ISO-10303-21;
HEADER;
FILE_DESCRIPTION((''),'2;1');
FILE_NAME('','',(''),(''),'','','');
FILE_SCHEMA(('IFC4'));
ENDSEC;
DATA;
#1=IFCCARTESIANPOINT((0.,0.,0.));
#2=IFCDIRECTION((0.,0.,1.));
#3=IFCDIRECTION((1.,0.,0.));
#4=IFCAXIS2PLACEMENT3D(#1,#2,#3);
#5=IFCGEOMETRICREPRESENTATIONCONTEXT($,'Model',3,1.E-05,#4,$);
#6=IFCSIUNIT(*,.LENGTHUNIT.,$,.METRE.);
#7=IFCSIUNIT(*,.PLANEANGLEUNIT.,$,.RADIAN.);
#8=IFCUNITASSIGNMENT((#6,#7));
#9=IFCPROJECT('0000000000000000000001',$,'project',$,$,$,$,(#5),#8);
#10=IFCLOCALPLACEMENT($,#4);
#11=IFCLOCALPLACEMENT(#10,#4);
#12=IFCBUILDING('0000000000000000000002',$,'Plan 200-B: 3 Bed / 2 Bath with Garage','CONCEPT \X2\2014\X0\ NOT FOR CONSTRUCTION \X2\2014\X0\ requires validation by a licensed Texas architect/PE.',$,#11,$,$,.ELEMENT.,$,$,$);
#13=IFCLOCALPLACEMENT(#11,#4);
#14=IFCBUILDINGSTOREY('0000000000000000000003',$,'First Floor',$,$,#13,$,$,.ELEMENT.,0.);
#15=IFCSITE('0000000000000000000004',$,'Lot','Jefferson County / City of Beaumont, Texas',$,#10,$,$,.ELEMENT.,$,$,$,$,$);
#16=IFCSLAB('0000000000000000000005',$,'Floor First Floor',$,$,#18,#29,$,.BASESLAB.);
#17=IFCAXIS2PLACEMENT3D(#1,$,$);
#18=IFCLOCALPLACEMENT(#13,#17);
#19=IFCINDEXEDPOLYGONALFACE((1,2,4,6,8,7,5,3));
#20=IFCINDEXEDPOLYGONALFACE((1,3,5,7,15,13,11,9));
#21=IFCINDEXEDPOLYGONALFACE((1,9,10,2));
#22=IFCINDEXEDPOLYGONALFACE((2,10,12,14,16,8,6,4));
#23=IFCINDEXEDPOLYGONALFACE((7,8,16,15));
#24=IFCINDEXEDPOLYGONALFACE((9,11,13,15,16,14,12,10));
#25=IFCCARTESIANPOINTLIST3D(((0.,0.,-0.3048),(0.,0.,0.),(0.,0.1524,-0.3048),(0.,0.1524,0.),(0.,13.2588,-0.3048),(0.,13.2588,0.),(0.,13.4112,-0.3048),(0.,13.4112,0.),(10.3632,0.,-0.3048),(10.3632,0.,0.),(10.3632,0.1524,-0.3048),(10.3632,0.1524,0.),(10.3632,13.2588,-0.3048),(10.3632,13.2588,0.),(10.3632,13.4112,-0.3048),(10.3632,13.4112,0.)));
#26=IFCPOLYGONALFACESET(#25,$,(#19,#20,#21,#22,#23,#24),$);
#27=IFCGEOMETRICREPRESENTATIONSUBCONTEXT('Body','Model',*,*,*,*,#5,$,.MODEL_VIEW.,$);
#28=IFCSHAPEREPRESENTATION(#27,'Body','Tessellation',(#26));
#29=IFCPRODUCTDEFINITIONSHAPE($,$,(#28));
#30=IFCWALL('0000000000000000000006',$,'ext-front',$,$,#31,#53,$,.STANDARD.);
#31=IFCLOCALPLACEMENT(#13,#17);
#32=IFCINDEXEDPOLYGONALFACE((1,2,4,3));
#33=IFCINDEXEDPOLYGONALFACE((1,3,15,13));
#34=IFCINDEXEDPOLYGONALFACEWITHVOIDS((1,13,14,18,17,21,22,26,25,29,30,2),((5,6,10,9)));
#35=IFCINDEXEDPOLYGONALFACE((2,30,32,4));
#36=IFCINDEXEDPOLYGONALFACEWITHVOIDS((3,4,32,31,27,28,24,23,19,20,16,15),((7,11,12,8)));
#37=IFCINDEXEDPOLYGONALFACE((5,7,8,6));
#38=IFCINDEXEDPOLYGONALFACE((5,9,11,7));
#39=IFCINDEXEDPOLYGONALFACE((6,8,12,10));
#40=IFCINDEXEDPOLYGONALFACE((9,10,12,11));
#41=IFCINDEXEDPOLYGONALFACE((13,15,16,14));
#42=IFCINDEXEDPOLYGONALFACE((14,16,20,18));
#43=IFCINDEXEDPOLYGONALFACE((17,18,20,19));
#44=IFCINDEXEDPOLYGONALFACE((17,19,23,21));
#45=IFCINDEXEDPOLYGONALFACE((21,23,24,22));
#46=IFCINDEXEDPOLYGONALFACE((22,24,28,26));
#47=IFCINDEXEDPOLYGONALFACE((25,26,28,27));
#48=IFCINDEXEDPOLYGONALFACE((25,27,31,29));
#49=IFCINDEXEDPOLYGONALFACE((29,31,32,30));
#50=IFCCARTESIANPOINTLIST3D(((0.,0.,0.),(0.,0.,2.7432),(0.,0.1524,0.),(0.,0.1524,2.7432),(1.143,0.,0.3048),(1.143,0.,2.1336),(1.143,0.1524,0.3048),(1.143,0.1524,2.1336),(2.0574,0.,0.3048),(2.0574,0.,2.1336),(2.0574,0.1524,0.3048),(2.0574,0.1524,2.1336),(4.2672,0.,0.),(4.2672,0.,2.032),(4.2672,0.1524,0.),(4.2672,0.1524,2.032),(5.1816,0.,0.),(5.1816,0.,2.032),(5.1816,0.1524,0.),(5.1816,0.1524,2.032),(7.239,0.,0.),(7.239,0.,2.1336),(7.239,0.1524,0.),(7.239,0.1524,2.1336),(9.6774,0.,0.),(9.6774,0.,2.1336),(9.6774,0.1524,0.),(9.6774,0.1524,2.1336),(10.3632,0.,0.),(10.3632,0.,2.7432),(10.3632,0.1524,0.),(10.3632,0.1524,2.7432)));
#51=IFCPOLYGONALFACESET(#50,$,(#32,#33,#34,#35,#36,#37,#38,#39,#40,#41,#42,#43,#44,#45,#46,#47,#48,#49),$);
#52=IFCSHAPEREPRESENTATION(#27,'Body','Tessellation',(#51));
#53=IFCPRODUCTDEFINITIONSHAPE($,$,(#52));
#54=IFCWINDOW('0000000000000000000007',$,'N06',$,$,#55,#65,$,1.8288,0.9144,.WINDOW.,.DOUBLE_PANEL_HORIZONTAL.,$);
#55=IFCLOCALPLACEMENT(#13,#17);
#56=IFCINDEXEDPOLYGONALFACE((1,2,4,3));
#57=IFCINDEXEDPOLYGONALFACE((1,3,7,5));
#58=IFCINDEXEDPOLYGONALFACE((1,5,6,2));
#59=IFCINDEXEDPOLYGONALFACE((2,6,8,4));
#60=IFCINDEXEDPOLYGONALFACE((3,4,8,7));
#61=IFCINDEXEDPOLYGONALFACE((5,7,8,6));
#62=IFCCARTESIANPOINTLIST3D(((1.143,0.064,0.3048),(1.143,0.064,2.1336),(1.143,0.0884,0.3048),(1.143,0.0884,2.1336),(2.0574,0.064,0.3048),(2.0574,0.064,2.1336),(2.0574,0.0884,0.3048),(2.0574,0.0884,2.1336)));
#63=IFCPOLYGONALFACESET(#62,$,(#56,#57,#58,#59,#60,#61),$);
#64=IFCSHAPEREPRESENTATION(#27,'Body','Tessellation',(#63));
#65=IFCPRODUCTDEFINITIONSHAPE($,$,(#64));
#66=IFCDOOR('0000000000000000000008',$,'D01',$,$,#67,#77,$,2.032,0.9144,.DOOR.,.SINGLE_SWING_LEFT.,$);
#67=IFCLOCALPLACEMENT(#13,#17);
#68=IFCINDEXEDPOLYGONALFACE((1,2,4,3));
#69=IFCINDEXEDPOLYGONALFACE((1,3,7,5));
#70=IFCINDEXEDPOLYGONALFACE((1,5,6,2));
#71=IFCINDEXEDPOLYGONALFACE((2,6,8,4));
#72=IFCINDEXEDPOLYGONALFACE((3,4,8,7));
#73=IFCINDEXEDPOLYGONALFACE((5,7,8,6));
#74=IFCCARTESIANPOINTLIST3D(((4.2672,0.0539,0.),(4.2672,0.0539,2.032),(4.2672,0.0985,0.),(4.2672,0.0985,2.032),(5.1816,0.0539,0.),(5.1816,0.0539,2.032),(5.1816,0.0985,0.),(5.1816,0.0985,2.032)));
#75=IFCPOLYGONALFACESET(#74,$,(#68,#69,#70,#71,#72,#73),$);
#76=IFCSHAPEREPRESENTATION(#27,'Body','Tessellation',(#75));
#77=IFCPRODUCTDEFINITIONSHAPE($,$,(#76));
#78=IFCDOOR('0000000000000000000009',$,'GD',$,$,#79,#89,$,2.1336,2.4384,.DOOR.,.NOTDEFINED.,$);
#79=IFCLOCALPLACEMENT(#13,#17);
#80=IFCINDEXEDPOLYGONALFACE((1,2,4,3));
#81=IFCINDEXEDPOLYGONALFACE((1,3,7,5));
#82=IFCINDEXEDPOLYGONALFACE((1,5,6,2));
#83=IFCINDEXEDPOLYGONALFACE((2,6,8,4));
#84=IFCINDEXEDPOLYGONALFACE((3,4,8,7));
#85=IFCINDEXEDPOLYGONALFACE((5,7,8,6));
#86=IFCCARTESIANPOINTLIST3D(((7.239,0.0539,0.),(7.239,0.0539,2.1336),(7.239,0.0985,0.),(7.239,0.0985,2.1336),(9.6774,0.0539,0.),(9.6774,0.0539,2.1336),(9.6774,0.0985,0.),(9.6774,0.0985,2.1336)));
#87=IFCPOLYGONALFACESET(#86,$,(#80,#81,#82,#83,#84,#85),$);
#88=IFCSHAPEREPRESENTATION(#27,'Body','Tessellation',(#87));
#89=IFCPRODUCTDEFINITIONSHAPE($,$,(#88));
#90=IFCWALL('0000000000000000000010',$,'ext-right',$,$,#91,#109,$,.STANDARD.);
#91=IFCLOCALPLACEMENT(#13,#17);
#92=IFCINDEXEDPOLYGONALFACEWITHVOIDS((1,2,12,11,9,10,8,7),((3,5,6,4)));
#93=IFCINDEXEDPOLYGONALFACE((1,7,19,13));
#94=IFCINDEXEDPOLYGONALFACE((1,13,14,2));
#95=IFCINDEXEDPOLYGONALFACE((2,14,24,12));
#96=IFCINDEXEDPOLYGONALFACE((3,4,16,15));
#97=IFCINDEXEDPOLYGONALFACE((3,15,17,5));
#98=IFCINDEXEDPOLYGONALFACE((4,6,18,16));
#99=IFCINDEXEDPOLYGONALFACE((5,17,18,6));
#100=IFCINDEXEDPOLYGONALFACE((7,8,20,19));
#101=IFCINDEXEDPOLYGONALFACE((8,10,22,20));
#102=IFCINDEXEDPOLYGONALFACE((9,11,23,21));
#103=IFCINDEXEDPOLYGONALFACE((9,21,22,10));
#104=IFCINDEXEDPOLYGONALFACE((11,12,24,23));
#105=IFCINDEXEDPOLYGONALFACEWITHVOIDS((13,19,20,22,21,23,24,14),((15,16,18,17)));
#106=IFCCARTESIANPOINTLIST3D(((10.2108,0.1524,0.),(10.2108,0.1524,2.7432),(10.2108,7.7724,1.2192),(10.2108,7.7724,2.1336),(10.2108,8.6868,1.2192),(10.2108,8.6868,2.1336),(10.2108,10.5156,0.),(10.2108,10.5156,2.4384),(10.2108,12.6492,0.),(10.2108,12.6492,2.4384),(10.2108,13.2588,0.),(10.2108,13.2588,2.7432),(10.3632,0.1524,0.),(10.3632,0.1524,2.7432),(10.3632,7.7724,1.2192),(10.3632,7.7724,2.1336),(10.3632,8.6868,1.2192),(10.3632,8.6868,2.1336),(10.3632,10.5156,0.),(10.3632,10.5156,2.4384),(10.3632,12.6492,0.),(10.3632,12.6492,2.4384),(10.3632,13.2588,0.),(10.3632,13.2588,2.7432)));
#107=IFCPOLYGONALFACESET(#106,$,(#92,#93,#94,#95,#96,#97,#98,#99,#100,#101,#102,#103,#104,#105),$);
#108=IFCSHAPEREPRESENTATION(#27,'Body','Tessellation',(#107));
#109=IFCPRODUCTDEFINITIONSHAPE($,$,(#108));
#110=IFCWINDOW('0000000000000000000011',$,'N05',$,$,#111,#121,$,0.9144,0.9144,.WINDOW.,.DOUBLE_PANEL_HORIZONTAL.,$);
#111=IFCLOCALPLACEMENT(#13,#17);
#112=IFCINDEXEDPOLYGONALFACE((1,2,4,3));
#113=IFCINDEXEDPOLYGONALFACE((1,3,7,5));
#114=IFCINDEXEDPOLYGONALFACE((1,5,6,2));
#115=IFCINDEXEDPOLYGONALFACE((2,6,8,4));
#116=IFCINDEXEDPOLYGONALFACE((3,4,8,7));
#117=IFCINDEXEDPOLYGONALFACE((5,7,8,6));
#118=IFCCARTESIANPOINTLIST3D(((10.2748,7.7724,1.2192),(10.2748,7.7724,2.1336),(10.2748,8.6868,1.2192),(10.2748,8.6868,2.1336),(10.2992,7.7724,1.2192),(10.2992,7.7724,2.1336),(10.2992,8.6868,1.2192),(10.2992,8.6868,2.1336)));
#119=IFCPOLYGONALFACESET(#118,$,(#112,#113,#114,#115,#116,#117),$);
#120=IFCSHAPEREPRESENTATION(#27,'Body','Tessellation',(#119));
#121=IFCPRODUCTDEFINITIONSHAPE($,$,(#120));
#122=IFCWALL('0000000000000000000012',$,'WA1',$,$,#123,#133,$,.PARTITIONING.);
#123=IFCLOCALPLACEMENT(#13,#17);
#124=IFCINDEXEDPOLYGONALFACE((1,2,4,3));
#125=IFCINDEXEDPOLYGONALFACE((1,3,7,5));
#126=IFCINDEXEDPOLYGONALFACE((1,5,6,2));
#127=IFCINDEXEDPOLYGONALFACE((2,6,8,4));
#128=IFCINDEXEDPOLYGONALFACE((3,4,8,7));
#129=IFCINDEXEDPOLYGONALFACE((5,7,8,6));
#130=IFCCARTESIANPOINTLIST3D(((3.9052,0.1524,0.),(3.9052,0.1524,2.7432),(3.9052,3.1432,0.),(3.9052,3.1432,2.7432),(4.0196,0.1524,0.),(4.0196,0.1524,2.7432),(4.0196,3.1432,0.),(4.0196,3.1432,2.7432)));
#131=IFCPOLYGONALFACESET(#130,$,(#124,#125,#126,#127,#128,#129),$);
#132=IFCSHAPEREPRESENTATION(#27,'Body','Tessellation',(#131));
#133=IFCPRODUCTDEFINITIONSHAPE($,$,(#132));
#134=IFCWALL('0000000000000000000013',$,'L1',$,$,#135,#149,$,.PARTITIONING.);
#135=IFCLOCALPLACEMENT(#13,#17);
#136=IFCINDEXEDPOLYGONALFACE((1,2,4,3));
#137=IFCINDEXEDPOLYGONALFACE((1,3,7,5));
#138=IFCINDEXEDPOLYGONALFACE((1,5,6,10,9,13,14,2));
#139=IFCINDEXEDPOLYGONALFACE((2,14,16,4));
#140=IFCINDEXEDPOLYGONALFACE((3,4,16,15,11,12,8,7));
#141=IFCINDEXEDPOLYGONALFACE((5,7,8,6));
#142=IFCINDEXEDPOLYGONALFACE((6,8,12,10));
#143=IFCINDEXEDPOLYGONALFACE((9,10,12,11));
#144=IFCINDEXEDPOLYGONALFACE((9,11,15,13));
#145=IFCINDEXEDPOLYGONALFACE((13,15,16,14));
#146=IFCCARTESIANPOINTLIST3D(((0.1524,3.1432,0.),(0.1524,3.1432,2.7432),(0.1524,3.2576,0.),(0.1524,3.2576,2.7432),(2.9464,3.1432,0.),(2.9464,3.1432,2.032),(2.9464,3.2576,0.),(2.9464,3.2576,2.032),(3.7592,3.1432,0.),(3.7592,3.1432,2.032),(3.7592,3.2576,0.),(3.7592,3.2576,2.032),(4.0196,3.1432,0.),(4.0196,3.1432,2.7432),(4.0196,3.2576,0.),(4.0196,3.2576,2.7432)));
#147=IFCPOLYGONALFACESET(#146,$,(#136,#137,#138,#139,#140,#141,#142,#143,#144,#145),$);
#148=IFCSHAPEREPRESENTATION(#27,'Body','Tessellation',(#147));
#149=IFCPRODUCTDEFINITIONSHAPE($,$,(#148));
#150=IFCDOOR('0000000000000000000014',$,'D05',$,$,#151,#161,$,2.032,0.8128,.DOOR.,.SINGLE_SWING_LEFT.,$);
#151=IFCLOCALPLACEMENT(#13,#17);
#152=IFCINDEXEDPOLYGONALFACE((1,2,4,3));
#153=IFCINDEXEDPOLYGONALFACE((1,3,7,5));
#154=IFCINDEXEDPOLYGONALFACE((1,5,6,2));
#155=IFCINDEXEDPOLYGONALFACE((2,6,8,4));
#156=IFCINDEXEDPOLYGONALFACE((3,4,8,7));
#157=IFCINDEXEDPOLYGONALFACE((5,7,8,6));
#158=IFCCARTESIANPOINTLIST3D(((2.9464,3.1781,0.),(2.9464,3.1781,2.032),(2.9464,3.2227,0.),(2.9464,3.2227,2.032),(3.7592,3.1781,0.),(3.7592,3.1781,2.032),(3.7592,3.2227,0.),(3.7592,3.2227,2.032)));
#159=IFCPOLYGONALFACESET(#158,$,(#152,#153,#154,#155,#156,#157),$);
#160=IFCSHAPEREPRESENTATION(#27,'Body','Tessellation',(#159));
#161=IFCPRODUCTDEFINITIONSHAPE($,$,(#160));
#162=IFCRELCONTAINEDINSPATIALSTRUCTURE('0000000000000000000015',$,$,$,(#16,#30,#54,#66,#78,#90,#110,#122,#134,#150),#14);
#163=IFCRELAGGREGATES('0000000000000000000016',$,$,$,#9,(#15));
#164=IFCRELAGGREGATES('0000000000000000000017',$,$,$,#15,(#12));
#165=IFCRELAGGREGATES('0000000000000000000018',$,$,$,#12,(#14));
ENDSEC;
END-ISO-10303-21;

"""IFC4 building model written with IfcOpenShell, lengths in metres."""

from ifc_helpers import new_model, si_unit, frame, frame_2d, origin_with_axes, place, context, subcontext, project, spatial, polyline, rectangle, outline, extrude, element, fill, save


model = new_model("IFC4")

# Units and contexts
model_context = context("Model", 3, precision=1e-05, world=origin_with_axes())
body_context = subcontext(model_context, "Body", "Model", "MODEL_VIEW")
ifc_project = project(units=[si_unit("LENGTHUNIT", "METRE"), si_unit("PLANEANGLEUNIT", "RADIAN")], contexts=[model_context])

# Site, building, storey
site_placement = place(None, origin_with_axes())
site = spatial("IfcSite", under=ifc_project, at=site_placement, Name="Lot", Description="Jefferson County / City of Beaumont, Texas", CompositionType="ELEMENT")
building_placement = place(site_placement, origin_with_axes())
building = spatial("IfcBuilding", under=site, at=building_placement, Name="Plan 200-B: 3 Bed / 2 Bath with Garage", Description="CONCEPT — NOT FOR CONSTRUCTION — requires validation by a licensed Texas architect/PE.", CompositionType="ELEMENT")
storey_placement = place(building_placement, origin_with_axes())
storey = spatial("IfcBuildingStorey", under=building, at=storey_placement, Name="First Floor", CompositionType="ELEMENT", Elevation=0.0)

# Slab
slab_placement = place(storey_placement, frame((0.0, 0.0, -0.3048), z_axis=(0.0, 0.0, 1.0), x_axis=(1.0, 0.0, 0.0)))
element("IfcSlab", 1, at=slab_placement, inside=storey, Name="Floor First Floor", PredefinedType="BASESLAB", context=body_context, shape_type="SweptSolid", body=[
    extrude(outline(polyline([(10.3632, 0.1524), (10.3632, 0.0), (0.0, 0.0), (0.0, 0.1524), (0.0, 13.2588), (0.0, 13.4112), (10.3632, 13.4112), (10.3632, 13.2588), (10.3632, 0.1524)])), origin_with_axes(), (0.0, 0.0, 1.0), 0.3048),
])

# Wall, openings, window, doors
wall_1_placement = place(storey_placement, frame((0.0, 0.0762, 0.0), z_axis=(0.0, 0.0, 1.0), x_axis=(1.0, 0.0, 0.0)))
wall_1 = element("IfcWall", 2, at=wall_1_placement, inside=storey, Name="ext-front", PredefinedType="STANDARD", context=body_context, shape_type="SweptSolid", body=[
    extrude(rectangle(XDim=10.3632, YDim=0.1524, at=frame_2d((5.1816, 0.0), x_axis=(1.0, 0.0))), origin_with_axes(), (0.0, 0.0, 1.0), 2.7432),
])
opening_1_placement = place(wall_1_placement, frame((1.143, 0.0, 0.3048), z_axis=(0.0, 0.0, 1.0), x_axis=(1.0, 0.0, 0.0)))
opening_1 = element("IfcOpeningElement", 3, at=opening_1_placement, cuts=wall_1, PredefinedType="OPENING", context=body_context, shape_type="SweptSolid", body=[
    extrude(rectangle(XDim=0.9144, YDim=0.1829, at=frame_2d((0.4572, 0.0), x_axis=(1.0, 0.0))), origin_with_axes(), (0.0, 0.0, 1.0), 1.8288),
])
opening_2_placement = place(wall_1_placement, frame((4.2672, 0.0, 0.0), z_axis=(0.0, 0.0, 1.0), x_axis=(1.0, 0.0, 0.0)))
opening_2 = element("IfcOpeningElement", 4, at=opening_2_placement, cuts=wall_1, PredefinedType="OPENING", context=body_context, shape_type="SweptSolid", body=[
    extrude(rectangle(XDim=0.9144, YDim=0.1829, at=frame_2d((0.4572, 0.0), x_axis=(1.0, 0.0))), origin_with_axes(), (0.0, 0.0, 1.0), 2.032),
])
opening_3_placement = place(wall_1_placement, frame((7.239, 0.0, 0.0), z_axis=(0.0, 0.0, 1.0), x_axis=(1.0, 0.0, 0.0)))
opening_3 = element("IfcOpeningElement", 5, at=opening_3_placement, cuts=wall_1, PredefinedType="OPENING", context=body_context, shape_type="SweptSolid", body=[
    extrude(rectangle(XDim=2.4384, YDim=0.1829, at=frame_2d((1.2192, 0.0), x_axis=(1.0, 0.0))), origin_with_axes(), (0.0, 0.0, 1.0), 2.1336),
])
window_1_placement = place(opening_1_placement, origin_with_axes())
window_1 = element("IfcWindow", 6, at=window_1_placement, inside=storey, Name="N06", OverallHeight=1.8288, OverallWidth=0.9144, PartitioningType="DOUBLE_PANEL_HORIZONTAL", PredefinedType="WINDOW", context=body_context, shape_type="SweptSolid", body=[
    extrude(rectangle(XDim=0.9144, YDim=0.0244, at=frame_2d((0.4572, 0.0), x_axis=(1.0, 0.0))), origin_with_axes(), (0.0, 0.0, 1.0), 1.8288),
])
fill(opening_1, window_1)
door_1_placement = place(opening_2_placement, origin_with_axes())
door_1 = element("IfcDoor", 7, at=door_1_placement, inside=storey, Name="D01", OperationType="SINGLE_SWING_LEFT", OverallHeight=2.032, OverallWidth=0.9144, PredefinedType="DOOR", context=body_context, shape_type="SweptSolid", body=[
    extrude(rectangle(XDim=0.9144, YDim=0.0445, at=frame_2d((0.4572, 0.0), x_axis=(1.0, 0.0))), origin_with_axes(), (0.0, 0.0, 1.0), 2.032),
])
fill(opening_2, door_1)
door_2_placement = place(opening_3_placement, origin_with_axes())
door_2 = element("IfcDoor", 8, at=door_2_placement, inside=storey, Name="GD", OperationType="NOTDEFINED", OverallHeight=2.1336, OverallWidth=2.4384, PredefinedType="DOOR", context=body_context, shape_type="SweptSolid", body=[
    extrude(rectangle(XDim=2.4384, YDim=0.0445, at=frame_2d((1.2192, 0.0), x_axis=(1.0, 0.0))), origin_with_axes(), (0.0, 0.0, 1.0), 2.1336),
])
fill(opening_3, door_2)

# Wall, openings, window
wall_2_placement = place(storey_placement, frame((10.287, 0.1524, 0.0), z_axis=(0.0, 0.0, 1.0), x_axis=(0.0, 1.0, 0.0)))
wall_2 = element("IfcWall", 9, at=wall_2_placement, inside=storey, Name="ext-right", PredefinedType="STANDARD", context=body_context, shape_type="SweptSolid", body=[
    extrude(rectangle(XDim=13.1064, YDim=0.1524, at=frame_2d((6.5532, 0.0), x_axis=(1.0, 0.0))), origin_with_axes(), (0.0, 0.0, 1.0), 2.7432),
])
opening_4_placement = place(wall_2_placement, frame((7.62, 0.0, 1.2192), z_axis=(0.0, 0.0, 1.0), x_axis=(1.0, 0.0, 0.0)))
opening_4 = element("IfcOpeningElement", 10, at=opening_4_placement, cuts=wall_2, PredefinedType="OPENING", context=body_context, shape_type="SweptSolid", body=[
    extrude(rectangle(XDim=0.9144, YDim=0.1829, at=frame_2d((0.4572, 0.0), x_axis=(1.0, 0.0))), origin_with_axes(), (0.0, 0.0, 1.0), 0.9144),
])
opening_5_placement = place(wall_2_placement, frame((10.3632, 0.0, 0.0), z_axis=(0.0, 0.0, 1.0), x_axis=(1.0, 0.0, 0.0)))
element("IfcOpeningElement", 11, at=opening_5_placement, cuts=wall_2, PredefinedType="OPENING", context=body_context, shape_type="SweptSolid", body=[
    extrude(rectangle(XDim=2.1336, YDim=0.1829, at=frame_2d((1.0668, 0.0), x_axis=(1.0, 0.0))), origin_with_axes(), (0.0, 0.0, 1.0), 2.4384),
])
window_2_placement = place(opening_4_placement, origin_with_axes())
window_2 = element("IfcWindow", 12, at=window_2_placement, inside=storey, Name="N05", OverallHeight=0.9144, OverallWidth=0.9144, PartitioningType="DOUBLE_PANEL_HORIZONTAL", PredefinedType="WINDOW", context=body_context, shape_type="SweptSolid", body=[
    extrude(rectangle(XDim=0.9144, YDim=0.0244, at=frame_2d((0.4572, 0.0), x_axis=(1.0, 0.0))), origin_with_axes(), (0.0, 0.0, 1.0), 0.9144),
])
fill(opening_4, window_2)

# Wall
wall_3_placement = place(storey_placement, frame((3.9624, 0.1524, 0.0), z_axis=(0.0, 0.0, 1.0), x_axis=(0.0, 1.0, 0.0)))
element("IfcWall", 13, at=wall_3_placement, inside=storey, Name="WA1", PredefinedType="PARTITIONING", context=body_context, shape_type="SweptSolid", body=[
    extrude(rectangle(XDim=2.9909, YDim=0.1143, at=frame_2d((1.4954, 0.0), x_axis=(1.0, 0.0))), origin_with_axes(), (0.0, 0.0, 1.0), 2.7432),
])

# Wall, opening, door
wall_4_placement = place(storey_placement, frame((0.1524, 3.2004, 0.0), z_axis=(0.0, 0.0, 1.0), x_axis=(1.0, 0.0, 0.0)))
wall_4 = element("IfcWall", 14, at=wall_4_placement, inside=storey, Name="L1", PredefinedType="PARTITIONING", context=body_context, shape_type="SweptSolid", body=[
    extrude(rectangle(XDim=3.8672, YDim=0.1143, at=frame_2d((1.9336, 0.0), x_axis=(1.0, 0.0))), origin_with_axes(), (0.0, 0.0, 1.0), 2.7432),
])
opening_6_placement = place(wall_4_placement, frame((2.794, 0.0, 0.0), z_axis=(0.0, 0.0, 1.0), x_axis=(1.0, 0.0, 0.0)))
opening_6 = element("IfcOpeningElement", 15, at=opening_6_placement, cuts=wall_4, PredefinedType="OPENING", context=body_context, shape_type="SweptSolid", body=[
    extrude(rectangle(XDim=0.8128, YDim=0.1448, at=frame_2d((0.4064, 0.0), x_axis=(1.0, 0.0))), origin_with_axes(), (0.0, 0.0, 1.0), 2.032),
])
door_3_placement = place(opening_6_placement, origin_with_axes())
door_3 = element("IfcDoor", 16, at=door_3_placement, inside=storey, Name="D05", OperationType="SINGLE_SWING_LEFT", OverallHeight=2.032, OverallWidth=0.8128, PredefinedType="DOOR", context=body_context, shape_type="SweptSolid", body=[
    extrude(rectangle(XDim=0.8128, YDim=0.0445, at=frame_2d((0.4064, 0.0), x_axis=(1.0, 0.0))), origin_with_axes(), (0.0, 0.0, 1.0), 2.032),
])
fill(opening_6, door_3)

save(model, "model.ifc")
